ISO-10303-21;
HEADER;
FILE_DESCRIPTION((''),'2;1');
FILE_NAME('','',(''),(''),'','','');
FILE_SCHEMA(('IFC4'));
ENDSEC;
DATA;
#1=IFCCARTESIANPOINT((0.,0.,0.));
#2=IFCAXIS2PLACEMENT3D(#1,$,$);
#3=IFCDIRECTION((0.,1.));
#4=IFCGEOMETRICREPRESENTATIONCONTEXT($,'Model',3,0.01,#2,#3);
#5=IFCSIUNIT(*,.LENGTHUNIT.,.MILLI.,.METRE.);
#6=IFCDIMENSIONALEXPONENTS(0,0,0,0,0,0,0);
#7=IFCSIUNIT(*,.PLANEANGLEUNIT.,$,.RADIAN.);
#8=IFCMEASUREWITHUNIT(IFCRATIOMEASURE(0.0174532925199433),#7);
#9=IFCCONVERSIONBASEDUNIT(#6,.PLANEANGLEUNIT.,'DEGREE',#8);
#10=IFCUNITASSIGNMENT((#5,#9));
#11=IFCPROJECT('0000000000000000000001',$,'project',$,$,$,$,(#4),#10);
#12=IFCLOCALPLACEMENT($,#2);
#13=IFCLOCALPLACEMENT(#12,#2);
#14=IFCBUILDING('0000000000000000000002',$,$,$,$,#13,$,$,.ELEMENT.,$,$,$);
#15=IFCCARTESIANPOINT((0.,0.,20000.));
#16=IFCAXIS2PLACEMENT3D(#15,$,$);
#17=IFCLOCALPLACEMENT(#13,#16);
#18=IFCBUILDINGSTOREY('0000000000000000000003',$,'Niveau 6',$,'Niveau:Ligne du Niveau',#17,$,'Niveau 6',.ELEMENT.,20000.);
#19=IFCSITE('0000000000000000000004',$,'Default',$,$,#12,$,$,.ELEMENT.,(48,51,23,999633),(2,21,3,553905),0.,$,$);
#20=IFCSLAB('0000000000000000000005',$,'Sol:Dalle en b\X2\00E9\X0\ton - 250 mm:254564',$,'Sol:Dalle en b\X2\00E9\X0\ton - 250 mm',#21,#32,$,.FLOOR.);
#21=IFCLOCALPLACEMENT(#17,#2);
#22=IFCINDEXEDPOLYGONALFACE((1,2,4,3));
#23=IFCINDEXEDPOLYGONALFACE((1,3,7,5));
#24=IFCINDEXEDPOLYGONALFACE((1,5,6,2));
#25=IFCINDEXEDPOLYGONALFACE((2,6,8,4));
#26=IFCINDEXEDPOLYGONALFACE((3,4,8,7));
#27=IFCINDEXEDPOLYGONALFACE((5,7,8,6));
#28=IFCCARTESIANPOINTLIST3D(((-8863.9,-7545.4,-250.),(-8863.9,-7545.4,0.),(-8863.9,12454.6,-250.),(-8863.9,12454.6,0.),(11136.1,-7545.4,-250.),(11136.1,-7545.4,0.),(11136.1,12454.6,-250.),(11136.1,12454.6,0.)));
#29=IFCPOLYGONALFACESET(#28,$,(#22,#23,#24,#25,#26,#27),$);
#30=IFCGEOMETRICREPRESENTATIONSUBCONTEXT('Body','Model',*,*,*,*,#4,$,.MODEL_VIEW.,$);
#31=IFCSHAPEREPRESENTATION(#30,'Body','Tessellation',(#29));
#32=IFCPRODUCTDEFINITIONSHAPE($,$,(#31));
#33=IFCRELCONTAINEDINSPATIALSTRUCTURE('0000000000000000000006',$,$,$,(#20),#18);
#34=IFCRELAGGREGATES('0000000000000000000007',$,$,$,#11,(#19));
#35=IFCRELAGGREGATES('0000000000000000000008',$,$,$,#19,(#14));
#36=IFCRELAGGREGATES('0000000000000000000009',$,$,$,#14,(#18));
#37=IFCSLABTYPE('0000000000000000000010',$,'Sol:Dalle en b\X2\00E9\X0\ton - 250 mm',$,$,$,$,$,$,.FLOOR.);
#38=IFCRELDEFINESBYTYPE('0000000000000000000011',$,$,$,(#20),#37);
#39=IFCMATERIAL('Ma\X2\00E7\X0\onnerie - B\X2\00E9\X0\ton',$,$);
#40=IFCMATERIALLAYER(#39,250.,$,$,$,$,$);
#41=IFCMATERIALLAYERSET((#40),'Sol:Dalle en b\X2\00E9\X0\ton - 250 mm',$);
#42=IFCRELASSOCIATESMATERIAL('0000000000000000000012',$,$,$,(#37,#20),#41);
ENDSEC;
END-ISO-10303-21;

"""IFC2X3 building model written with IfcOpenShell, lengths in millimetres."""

from ifc_helpers import new_model, entity, si_unit, converted_unit, direction, frame, origin, origin_2d_with_axis, place, context, subcontext, project, spatial, rectangle, extrude, material, layer, layer_set, layer_usage, type_object, element, save


model = new_model("IFC2X3")

# Units and contexts
model_context = context("Model", 3, precision=0.01, world=origin(), true_north=direction((0.0, 1.0)))
body_context = subcontext(model_context, "Body", "Model", "MODEL_VIEW")
ifc_project = project(units=[si_unit("LENGTHUNIT", "METRE", prefix="MILLI"), converted_unit("PLANEANGLEUNIT", "DEGREE", entity("IfcRatioMeasure", 0.0174532925199433), si_unit("PLANEANGLEUNIT", "RADIAN"), dimensions=[0, 0, 0, 0, 0, 0, 0])], contexts=[model_context])

# Site, building, storey
site_placement = place(None, origin())
site = spatial("IfcSite", under=ifc_project, at=site_placement, Name="Default", CompositionType="ELEMENT", RefLatitude=(48, 51, 23, 999633), RefLongitude=(2, 21, 3, 553905), RefElevation=0.0)
building_placement = place(site_placement, origin())
building = spatial("IfcBuilding", under=site, at=building_placement, CompositionType="ELEMENT")
storey_placement = place(building_placement, frame((0.0, 0.0, 20000.0)))
storey = spatial("IfcBuildingStorey", under=building, at=storey_placement, Name="Niveau 6", ObjectType="Niveau:Ligne du Niveau", LongName="Niveau 6", CompositionType="ELEMENT", Elevation=20000.0)

# Slab
ifc_material = material(Name="Maçonnerie - Béton")
ifc_layer = layer(ifc_material, 250.0)
ifc_layer_set = layer_set([ifc_layer], Name="Sol:Dalle en béton - 250 mm")
ifc_layer_usage = layer_usage(ifc_layer_set, "AXIS3", "POSITIVE", 0.0)
slab_type = type_object("IfcSlabType", Name="Sol:Dalle en béton - 250 mm", PredefinedType="FLOOR", material=ifc_layer_set)
slab_placement = place(storey_placement, origin())
element("IfcSlab", 1, at=slab_placement, inside=storey, type_object=slab_type, material=ifc_layer_usage, Name="Sol:Dalle en béton - 250 mm:254564", ObjectType="Sol:Dalle en béton - 250 mm", PredefinedType="FLOOR", context=body_context, shape_type="SweptSolid", body=[
    extrude(rectangle(XDim=20000.0, YDim=20000.0, at=origin_2d_with_axis()), frame((1136.1, 2454.6, 0.0), z_axis=(0.0, 0.0, -1.0), x_axis=(0.0, 1.0, 0.0)), (0.0, 0.0, 1.0), 250.0),
])

save(model, "model.ifc")
